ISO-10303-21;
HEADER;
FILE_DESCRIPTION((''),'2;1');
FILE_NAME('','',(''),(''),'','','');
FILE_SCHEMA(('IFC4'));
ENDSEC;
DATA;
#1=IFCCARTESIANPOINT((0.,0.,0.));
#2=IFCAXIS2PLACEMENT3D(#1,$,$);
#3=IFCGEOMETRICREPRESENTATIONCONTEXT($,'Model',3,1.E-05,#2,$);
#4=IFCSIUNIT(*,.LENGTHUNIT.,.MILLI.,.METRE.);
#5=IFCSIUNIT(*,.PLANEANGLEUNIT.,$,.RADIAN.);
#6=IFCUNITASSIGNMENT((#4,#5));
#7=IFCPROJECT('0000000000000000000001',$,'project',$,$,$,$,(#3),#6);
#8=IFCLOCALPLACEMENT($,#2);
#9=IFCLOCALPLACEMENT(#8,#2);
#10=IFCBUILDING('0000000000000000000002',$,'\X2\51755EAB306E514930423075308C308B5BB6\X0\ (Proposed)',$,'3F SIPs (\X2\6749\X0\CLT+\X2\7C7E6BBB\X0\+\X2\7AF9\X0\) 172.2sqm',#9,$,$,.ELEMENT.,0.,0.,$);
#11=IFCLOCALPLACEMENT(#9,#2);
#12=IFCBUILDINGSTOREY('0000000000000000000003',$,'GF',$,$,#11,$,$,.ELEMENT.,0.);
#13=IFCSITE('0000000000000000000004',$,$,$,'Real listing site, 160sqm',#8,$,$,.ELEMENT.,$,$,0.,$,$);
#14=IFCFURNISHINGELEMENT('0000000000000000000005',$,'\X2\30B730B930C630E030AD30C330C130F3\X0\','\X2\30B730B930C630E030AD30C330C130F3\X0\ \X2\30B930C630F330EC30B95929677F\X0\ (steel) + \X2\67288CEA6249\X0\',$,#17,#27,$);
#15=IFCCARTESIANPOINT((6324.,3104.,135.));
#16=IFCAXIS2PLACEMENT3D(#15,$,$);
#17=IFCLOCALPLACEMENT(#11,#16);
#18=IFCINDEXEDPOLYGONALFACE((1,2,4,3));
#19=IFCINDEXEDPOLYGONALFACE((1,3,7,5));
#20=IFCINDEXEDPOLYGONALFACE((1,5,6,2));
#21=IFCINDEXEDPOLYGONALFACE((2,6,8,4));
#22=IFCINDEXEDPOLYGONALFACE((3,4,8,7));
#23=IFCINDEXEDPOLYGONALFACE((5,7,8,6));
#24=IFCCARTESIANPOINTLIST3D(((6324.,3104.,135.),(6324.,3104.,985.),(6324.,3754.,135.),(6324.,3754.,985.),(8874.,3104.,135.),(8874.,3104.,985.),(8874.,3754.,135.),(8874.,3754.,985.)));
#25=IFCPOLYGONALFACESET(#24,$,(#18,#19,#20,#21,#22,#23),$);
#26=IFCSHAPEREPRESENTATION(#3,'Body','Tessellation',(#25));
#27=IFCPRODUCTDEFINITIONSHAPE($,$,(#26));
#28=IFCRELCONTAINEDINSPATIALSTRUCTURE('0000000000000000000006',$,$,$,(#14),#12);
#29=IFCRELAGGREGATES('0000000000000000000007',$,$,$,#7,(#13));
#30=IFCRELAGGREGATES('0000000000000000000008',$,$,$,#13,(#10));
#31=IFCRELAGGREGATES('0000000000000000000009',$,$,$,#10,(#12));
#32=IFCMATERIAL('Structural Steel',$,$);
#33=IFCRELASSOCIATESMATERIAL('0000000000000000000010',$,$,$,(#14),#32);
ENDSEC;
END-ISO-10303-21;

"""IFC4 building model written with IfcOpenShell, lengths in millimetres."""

from ifc_helpers import new_model, si_unit, frame, frame_2d, origin, place, context, project, spatial, rectangle, extrude, material, element, save


model = new_model("IFC4")

# Units and contexts
model_context = context("Model", 3, precision=1e-05, world=origin())
ifc_project = project(units=[si_unit("LENGTHUNIT", "METRE", prefix="MILLI"), si_unit("PLANEANGLEUNIT", "RADIAN")], contexts=[model_context])

# Site, building, storey
site_placement = place(None, origin())
site = spatial("IfcSite", under=ifc_project, at=site_placement, ObjectType="Real listing site, 160sqm", CompositionType="ELEMENT", RefElevation=0.0)
building_placement = place(site_placement, origin())
building = spatial("IfcBuilding", under=site, at=building_placement, Name="兵庫の光あふれる家 (Proposed)", ObjectType="3F SIPs (杉CLT+籾殻+竹) 172.2sqm", CompositionType="ELEMENT", ElevationOfRefHeight=0.0, ElevationOfTerrain=0.0)
storey_placement = place(building_placement, origin())
storey = spatial("IfcBuildingStorey", under=building, at=storey_placement, Name="GF", CompositionType="ELEMENT", Elevation=0.0)

# Furnishing element
ifc_material_1 = material(Name="Structural Steel")
furnishing_1_placement = place(storey_placement, frame((6324.0, 3104.0, 135.0)))
element("IfcFurnishingElement", 1, at=furnishing_1_placement, inside=storey, material=ifc_material_1, Name="システムキッチン", Description="システムキッチン ステンレス天板 (steel) + 木質扉", context=model_context, shape_type="SweptSolid", body=[
    extrude(rectangle(XDim=2550.0, YDim=650.0, at=frame_2d((1275.0, 325.0))), frame((6324.0, 3104.0, 135.0)), (0.0, 0.0, 1.0), 850.0),
])

save(model, "model.ifc")
